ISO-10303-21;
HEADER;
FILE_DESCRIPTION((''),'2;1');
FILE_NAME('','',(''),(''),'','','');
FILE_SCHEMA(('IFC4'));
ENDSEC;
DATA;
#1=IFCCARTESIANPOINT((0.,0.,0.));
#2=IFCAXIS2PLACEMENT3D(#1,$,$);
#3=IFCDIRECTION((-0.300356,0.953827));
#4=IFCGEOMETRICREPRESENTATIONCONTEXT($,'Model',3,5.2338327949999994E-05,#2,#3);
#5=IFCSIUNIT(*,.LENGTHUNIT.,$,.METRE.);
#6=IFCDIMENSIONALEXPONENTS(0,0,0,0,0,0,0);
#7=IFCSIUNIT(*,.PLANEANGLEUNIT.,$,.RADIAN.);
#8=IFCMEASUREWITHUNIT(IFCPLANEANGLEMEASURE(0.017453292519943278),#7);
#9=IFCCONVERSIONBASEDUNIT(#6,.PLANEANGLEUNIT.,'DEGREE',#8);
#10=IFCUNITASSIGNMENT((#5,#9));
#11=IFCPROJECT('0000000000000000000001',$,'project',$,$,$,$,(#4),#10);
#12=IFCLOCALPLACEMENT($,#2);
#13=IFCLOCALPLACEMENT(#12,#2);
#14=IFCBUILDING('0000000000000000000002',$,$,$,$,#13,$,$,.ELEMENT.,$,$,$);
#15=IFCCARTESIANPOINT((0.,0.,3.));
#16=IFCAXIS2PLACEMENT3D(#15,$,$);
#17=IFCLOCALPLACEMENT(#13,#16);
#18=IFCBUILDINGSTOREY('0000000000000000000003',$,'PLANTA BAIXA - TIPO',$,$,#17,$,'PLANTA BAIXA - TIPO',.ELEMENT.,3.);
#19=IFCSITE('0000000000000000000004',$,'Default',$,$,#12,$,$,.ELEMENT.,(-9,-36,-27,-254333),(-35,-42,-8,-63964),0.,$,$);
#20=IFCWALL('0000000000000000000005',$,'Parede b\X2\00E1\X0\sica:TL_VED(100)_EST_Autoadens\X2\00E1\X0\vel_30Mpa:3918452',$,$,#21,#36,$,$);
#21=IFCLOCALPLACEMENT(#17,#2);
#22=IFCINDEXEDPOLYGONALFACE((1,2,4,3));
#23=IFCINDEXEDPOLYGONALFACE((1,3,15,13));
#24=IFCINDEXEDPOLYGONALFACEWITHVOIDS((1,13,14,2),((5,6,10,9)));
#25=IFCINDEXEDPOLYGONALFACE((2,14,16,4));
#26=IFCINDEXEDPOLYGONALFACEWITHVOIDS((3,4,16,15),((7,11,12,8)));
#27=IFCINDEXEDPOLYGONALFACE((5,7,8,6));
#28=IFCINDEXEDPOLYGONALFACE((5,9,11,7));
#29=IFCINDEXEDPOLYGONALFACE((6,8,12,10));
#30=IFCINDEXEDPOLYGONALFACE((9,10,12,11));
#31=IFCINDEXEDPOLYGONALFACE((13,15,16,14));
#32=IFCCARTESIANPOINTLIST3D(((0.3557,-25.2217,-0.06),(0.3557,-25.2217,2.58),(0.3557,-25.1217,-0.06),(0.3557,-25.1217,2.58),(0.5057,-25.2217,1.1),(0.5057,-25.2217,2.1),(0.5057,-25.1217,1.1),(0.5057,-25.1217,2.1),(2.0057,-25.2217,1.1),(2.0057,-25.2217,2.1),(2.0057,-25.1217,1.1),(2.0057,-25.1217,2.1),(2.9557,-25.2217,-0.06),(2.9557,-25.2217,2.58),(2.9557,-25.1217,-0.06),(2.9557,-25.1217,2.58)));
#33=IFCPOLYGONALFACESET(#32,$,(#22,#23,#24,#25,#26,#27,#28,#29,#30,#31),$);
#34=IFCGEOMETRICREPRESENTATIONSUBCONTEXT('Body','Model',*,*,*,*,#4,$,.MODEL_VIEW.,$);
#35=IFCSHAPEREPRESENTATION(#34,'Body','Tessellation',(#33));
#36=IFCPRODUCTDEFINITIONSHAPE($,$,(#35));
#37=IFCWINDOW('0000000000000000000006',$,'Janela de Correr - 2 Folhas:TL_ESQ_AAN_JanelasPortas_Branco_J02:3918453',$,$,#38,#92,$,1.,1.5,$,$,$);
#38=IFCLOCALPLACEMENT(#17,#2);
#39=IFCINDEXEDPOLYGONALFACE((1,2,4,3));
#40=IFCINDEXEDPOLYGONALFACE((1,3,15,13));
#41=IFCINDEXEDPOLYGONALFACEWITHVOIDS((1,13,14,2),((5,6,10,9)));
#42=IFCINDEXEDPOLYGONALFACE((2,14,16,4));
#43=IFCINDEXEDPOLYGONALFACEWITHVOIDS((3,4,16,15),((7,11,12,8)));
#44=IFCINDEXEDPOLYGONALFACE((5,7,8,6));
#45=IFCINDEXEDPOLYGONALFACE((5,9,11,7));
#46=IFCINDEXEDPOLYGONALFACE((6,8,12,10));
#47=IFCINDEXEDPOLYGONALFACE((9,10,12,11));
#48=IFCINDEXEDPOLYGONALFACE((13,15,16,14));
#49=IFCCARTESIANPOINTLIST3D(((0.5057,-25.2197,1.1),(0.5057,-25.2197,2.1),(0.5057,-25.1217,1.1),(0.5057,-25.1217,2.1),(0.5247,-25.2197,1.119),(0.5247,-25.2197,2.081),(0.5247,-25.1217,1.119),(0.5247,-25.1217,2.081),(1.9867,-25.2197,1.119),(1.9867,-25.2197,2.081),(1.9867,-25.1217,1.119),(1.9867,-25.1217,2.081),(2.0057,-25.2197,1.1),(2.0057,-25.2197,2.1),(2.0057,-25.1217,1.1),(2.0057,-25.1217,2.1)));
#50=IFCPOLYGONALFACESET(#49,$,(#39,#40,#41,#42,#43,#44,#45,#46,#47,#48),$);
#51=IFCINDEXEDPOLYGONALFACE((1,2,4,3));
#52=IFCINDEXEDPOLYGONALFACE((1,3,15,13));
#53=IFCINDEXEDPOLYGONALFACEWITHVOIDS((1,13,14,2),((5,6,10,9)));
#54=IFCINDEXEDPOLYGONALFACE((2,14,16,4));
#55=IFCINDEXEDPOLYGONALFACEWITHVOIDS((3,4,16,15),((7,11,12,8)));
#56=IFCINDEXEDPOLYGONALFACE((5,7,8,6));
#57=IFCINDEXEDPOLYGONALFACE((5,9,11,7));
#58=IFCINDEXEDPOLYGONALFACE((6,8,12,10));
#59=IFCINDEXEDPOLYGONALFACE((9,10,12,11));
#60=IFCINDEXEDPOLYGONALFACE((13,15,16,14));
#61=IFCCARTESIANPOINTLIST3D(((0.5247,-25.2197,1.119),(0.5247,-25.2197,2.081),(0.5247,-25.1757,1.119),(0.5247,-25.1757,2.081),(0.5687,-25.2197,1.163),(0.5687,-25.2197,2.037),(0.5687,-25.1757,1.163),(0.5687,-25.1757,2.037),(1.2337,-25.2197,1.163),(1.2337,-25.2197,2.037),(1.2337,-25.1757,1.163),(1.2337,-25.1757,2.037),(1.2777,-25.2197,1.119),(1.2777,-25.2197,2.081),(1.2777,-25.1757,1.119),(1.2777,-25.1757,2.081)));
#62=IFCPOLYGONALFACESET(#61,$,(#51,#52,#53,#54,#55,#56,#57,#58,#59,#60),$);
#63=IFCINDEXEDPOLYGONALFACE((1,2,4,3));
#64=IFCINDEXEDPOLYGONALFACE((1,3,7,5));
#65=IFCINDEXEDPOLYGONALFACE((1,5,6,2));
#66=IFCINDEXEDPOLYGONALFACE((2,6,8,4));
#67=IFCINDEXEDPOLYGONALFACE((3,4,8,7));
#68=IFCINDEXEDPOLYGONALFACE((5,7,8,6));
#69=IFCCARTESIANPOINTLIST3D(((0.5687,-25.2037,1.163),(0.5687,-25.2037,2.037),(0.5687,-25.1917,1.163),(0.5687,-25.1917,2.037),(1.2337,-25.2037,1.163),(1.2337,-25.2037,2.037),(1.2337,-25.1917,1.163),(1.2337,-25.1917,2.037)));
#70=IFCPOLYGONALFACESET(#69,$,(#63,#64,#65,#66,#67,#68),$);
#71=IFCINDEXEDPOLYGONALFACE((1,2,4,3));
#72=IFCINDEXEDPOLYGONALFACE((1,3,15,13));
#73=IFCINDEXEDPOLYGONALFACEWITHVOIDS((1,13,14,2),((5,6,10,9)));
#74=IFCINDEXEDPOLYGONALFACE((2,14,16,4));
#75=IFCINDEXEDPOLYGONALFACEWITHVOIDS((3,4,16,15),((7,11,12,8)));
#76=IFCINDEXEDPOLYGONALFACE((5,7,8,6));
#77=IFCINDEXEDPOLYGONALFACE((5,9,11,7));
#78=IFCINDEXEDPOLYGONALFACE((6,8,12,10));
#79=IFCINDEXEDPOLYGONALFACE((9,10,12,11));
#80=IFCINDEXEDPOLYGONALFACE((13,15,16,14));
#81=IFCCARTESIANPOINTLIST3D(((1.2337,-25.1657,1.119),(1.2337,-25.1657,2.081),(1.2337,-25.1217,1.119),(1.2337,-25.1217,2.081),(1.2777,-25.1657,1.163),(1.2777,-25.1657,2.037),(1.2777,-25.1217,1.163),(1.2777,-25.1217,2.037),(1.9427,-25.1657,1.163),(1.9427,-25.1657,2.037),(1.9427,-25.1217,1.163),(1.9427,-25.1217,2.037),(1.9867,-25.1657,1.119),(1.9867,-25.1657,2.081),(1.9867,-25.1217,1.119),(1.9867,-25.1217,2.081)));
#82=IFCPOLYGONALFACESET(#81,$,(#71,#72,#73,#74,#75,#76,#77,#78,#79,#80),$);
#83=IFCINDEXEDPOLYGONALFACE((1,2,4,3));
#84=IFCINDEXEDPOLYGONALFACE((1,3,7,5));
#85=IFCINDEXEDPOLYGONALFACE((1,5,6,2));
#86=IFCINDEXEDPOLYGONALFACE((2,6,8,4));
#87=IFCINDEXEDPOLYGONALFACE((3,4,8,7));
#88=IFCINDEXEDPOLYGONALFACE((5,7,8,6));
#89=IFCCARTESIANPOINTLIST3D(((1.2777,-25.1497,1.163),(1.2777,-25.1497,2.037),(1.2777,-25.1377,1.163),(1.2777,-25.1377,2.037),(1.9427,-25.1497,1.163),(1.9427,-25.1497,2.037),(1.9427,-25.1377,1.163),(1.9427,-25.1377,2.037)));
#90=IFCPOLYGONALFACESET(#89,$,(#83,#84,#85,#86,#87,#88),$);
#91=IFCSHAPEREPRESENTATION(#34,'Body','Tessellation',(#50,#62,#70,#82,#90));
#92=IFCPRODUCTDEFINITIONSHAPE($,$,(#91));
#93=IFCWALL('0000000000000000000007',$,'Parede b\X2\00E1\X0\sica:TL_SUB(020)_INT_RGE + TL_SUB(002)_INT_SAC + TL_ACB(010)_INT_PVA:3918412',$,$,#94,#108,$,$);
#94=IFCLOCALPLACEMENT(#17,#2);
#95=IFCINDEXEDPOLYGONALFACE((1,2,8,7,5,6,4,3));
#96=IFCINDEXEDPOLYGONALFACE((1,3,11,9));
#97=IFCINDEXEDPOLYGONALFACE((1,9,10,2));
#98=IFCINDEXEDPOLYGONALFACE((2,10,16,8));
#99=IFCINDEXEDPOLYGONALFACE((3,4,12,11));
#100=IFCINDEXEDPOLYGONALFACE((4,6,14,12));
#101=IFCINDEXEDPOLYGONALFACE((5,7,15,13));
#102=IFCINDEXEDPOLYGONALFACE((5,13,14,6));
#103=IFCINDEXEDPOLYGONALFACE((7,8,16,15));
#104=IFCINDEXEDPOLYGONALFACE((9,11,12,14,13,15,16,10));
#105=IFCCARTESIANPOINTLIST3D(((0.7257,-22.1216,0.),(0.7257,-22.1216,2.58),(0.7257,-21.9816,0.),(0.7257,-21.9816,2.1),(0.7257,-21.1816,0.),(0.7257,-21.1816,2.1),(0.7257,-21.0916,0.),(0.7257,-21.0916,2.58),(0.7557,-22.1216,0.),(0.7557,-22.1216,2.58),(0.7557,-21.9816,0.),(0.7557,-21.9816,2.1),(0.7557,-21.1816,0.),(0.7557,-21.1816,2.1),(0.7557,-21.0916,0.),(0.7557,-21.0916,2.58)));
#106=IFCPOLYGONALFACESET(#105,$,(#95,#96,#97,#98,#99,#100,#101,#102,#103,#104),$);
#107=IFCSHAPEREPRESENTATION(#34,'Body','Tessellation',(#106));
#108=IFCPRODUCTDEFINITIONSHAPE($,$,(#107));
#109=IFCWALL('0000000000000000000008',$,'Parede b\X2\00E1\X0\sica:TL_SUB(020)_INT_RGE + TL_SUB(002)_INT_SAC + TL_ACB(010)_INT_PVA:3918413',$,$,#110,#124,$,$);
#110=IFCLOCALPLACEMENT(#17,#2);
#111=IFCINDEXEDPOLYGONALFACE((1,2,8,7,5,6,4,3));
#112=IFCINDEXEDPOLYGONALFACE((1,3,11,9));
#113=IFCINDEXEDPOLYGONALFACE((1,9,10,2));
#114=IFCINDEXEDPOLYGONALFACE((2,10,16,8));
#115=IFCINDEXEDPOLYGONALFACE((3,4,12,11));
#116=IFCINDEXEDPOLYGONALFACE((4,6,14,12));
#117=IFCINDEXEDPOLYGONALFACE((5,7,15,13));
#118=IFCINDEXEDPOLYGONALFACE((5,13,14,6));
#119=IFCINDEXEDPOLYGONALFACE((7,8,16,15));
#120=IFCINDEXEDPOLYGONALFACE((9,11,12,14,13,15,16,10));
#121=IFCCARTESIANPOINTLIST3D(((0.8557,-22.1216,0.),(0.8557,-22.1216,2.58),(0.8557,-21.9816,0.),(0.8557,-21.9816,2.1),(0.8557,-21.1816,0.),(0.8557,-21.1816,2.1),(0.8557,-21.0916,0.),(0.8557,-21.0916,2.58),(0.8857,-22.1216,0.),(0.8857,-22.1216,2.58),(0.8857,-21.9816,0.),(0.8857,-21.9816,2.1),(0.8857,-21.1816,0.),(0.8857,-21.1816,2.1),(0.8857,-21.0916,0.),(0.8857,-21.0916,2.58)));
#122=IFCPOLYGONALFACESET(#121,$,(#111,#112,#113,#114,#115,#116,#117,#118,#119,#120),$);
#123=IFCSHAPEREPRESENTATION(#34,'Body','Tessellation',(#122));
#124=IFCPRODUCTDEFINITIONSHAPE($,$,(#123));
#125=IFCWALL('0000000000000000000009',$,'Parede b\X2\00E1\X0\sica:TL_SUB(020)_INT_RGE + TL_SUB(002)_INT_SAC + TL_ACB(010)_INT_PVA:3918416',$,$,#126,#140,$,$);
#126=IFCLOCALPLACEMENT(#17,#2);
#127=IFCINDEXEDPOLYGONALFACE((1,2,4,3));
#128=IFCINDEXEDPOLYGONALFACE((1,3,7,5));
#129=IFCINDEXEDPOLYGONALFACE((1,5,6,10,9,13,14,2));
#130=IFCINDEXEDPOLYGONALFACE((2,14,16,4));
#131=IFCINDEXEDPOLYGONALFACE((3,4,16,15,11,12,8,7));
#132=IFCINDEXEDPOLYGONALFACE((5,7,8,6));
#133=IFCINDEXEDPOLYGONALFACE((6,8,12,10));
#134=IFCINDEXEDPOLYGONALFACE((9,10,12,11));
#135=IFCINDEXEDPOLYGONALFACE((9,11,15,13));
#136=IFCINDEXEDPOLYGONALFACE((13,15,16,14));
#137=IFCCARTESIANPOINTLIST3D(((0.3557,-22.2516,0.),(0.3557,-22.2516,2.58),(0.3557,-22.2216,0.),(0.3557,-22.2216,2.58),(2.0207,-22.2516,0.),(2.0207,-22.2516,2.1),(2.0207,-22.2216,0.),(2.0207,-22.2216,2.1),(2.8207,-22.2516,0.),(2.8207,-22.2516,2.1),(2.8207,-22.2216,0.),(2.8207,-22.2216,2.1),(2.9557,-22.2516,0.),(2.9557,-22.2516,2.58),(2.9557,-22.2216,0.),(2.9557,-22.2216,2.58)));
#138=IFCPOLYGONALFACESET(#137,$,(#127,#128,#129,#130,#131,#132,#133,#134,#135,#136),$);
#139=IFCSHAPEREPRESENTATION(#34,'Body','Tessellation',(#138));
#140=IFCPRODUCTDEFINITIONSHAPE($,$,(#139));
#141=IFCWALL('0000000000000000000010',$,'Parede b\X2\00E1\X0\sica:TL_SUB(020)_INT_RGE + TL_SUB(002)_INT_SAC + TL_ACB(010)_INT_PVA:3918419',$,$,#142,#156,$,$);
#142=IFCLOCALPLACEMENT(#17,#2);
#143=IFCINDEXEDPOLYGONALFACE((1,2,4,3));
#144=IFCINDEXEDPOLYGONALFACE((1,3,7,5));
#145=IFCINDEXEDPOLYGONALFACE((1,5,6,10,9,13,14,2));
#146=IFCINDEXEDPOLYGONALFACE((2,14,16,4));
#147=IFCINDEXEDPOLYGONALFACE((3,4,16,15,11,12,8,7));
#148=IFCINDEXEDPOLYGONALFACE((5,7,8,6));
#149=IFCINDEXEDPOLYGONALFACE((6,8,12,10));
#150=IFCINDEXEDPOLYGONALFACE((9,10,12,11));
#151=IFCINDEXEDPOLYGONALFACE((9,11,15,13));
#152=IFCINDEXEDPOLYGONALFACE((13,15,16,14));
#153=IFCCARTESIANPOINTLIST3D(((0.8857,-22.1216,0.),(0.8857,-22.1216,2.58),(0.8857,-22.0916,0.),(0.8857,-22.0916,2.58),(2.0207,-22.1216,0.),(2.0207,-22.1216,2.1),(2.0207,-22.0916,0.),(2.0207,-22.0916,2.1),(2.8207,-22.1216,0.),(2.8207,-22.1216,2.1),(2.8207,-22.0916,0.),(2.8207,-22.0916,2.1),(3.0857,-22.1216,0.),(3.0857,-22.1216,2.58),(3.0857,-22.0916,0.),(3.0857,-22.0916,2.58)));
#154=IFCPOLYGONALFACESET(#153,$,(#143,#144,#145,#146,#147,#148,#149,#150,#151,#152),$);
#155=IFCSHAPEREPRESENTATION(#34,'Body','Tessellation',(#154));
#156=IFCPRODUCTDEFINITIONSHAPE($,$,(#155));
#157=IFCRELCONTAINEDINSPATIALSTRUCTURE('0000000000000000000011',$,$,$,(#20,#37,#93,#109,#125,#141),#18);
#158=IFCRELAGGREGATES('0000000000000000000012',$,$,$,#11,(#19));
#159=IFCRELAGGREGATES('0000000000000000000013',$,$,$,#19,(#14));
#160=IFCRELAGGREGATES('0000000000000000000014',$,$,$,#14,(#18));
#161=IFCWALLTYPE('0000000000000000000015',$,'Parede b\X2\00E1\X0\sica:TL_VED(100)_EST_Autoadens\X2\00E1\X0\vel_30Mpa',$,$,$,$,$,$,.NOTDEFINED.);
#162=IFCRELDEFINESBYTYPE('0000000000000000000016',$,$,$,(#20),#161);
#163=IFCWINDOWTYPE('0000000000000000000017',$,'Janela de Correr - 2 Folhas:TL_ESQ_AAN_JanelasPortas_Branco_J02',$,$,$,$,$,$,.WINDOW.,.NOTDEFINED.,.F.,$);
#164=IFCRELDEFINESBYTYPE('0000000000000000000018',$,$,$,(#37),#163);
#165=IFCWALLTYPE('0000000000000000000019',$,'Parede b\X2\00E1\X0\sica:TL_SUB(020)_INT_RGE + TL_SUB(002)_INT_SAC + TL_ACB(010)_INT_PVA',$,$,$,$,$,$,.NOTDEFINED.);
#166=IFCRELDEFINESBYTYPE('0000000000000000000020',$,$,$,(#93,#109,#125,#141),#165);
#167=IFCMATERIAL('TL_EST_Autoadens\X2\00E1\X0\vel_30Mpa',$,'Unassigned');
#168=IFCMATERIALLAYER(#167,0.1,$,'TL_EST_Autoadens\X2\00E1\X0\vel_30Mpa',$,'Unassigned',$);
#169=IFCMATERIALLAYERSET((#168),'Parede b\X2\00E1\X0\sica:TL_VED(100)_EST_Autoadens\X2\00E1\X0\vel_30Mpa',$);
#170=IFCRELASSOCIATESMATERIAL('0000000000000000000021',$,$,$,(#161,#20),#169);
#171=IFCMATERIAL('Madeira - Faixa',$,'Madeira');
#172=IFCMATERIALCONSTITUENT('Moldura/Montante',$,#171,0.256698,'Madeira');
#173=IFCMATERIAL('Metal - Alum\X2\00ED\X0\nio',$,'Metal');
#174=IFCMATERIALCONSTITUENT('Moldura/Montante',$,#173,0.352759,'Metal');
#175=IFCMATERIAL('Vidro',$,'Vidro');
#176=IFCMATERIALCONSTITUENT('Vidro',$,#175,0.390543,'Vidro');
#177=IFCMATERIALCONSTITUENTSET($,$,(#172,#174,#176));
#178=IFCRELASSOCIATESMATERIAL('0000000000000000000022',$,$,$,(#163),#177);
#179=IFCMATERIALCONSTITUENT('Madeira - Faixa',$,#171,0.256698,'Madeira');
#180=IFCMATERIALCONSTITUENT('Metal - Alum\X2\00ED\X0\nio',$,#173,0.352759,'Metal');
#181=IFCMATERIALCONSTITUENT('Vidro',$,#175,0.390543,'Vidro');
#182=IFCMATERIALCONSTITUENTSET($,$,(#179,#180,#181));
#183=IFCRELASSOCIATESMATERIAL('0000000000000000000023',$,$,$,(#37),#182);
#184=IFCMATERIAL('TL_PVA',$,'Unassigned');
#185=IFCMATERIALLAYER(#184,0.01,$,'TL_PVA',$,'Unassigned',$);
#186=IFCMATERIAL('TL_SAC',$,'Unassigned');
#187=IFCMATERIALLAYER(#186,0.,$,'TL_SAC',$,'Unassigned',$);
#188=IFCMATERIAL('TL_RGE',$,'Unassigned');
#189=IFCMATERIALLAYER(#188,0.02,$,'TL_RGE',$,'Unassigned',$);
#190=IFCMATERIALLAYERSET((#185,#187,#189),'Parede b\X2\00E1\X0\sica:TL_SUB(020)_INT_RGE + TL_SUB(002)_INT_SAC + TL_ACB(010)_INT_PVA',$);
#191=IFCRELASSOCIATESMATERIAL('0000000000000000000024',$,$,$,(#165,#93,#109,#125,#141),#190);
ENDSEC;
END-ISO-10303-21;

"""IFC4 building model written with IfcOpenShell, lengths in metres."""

from ifc_helpers import new_model, entity, si_unit, converted_unit, direction, frame, frame_2d, origin, origin_2d_with_axis, place, context, subcontext, project, spatial, polyline, rectangle, outline, extrude, source, transform, mapped, material, layer, layer_set, layer_usage, constituent, constituent_set, type_object, type_shapes, element, fill, save


model = new_model("IFC4")

# Units and contexts
model_context = context("Model", 3, precision=5.2338327949999994e-05, world=origin(), true_north=direction((-0.300356, 0.953827)))
body_context = subcontext(model_context, "Body", "Model", "MODEL_VIEW")
ifc_project = project(units=[si_unit("LENGTHUNIT", "METRE"), converted_unit("PLANEANGLEUNIT", "DEGREE", entity("IfcPlaneAngleMeasure", 0.017453292519943278), si_unit("PLANEANGLEUNIT", "RADIAN"), dimensions=[0, 0, 0, 0, 0, 0, 0])], contexts=[model_context])

# Site, building, storey
site_placement = place(None, origin())
site = spatial("IfcSite", under=ifc_project, at=site_placement, Name="Default", CompositionType="ELEMENT", RefLatitude=(-9, -36, -27, -254333), RefLongitude=(-35, -42, -8, -63964), RefElevation=0.0)
building_placement = place(site_placement, origin())
building = spatial("IfcBuilding", under=site, at=building_placement, CompositionType="ELEMENT")
storey_placement = place(building_placement, frame((0.0, 0.0, 3.0)))
storey = spatial("IfcBuildingStorey", under=building, at=storey_placement, Name="PLANTA BAIXA - TIPO", LongName="PLANTA BAIXA - TIPO", CompositionType="ELEMENT", Elevation=3.0)

# Shared definitions
ifc_material_1 = material(Name="TL_EST_Autoadensável_30Mpa", Category="Unassigned")
ifc_layer_1 = layer(ifc_material_1, 0.1, Name="TL_EST_Autoadensável_30Mpa", Category="Unassigned")
ifc_layer_set_1 = layer_set([ifc_layer_1], Name="Parede básica:TL_VED(100)_EST_Autoadensável_30Mpa")
wall_type_1 = type_object("IfcWallType", Name="Parede básica:TL_VED(100)_EST_Autoadensável_30Mpa", PredefinedType="NOTDEFINED", material=ifc_layer_set_1)

# Shared definitions
ifc_material_2 = material(Name="Vidro", Category="Vidro")

# Wall, opening, window
ifc_layer_usage_1 = layer_usage(ifc_layer_set_1, "AXIS2", "POSITIVE", -0.05)
wall_1_placement = place(storey_placement, frame((0.3557, -25.1717, -0.06)))
wall_1 = element("IfcWall", 1, at=wall_1_placement, inside=storey, type_object=wall_type_1, material=ifc_layer_usage_1, Name="Parede básica:TL_VED(100)_EST_Autoadensável_30Mpa:3918452", context=body_context, shape_type="SweptSolid", body=[
    extrude(rectangle(XDim=2.6, YDim=0.1, at=frame_2d((1.3, 0.0), x_axis=(-1.0, 0.0))), origin(), (0.0, 0.0, 1.0), 2.64),
])
opening_1_placement = place(wall_1_placement, frame((1.65, 0.05, 1.16)))
opening_1 = element("IfcOpeningElement", 2, at=opening_1_placement, cuts=wall_1, PredefinedType="OPENING", context=body_context, shape_type="SweptSolid", body=[
    extrude(rectangle(XDim=1.0, YDim=1.5, at=frame_2d((0.5, 0.75), x_axis=(-1.0, 0.0))), frame((0.0, 0.0, 0.0), z_axis=(0.0, -1.0, 0.0), x_axis=(0.0, 0.0, 1.0)), (0.0, 0.0, 1.0), 0.1),
])
ifc_material_3 = material(Name="Madeira - Faixa", Category="Madeira")
ifc_constituent_1 = constituent(ifc_material_3, Name="Madeira - Faixa", Category="Madeira", fraction=0.256698)
ifc_material_4 = material(Name="Metal - Alumínio", Category="Metal")
ifc_constituent_2 = constituent(ifc_material_4, Name="Metal - Alumínio", Category="Metal", fraction=0.352759)
ifc_constituent_3 = constituent(ifc_material_2, Name="Vidro", Category="Vidro", fraction=0.390543)
ifc_constituent_set_1 = constituent_set(constituents=[ifc_constituent_1, ifc_constituent_2, ifc_constituent_3])
ifc_constituent_4 = constituent(ifc_material_3, Name="Moldura/Montante", Category="Madeira", fraction=0.256698)
ifc_constituent_5 = constituent(ifc_material_4, Name="Moldura/Montante", Category="Metal", fraction=0.352759)
ifc_constituent_6 = constituent(ifc_material_2, Name="Vidro", Category="Vidro", fraction=0.390543)
ifc_constituent_set_2 = constituent_set(constituents=[ifc_constituent_4, ifc_constituent_5, ifc_constituent_6])
window_type = type_object("IfcWindowType", Name="Janela de Correr - 2 Folhas:TL_ESQ_AAN_JanelasPortas_Branco_J02", ParameterTakesPrecedence=False, PartitioningType="NOTDEFINED", PredefinedType="WINDOW", material=ifc_constituent_set_2)
shared_shape_1 = source(origin(), body_context, "Body", "SweptSolid", [
    extrude(outline(polyline([(-0.75, -0.5), (0.75, -0.5), (0.75, 0.5), (-0.75, 0.5), (-0.75, -0.5)]), holes=[polyline([(-0.731, -0.481), (-0.731, 0.481), (0.731, 0.481), (0.731, -0.481), (-0.731, -0.481)])]), frame((0.75, 0.0, 0.5), z_axis=(0.0, 1.0, 0.0), x_axis=(1.0, 0.0, 0.0)), (0.0, 0.0, 1.0), 0.098),
    extrude(outline(polyline([(-0.3765, -0.481), (0.3765, -0.481), (0.3765, 0.481), (-0.3765, 0.481), (-0.3765, -0.481)]), holes=[polyline([(-0.3325, -0.437), (-0.3325, 0.437), (0.3325, 0.437), (0.3325, -0.437), (-0.3325, -0.437)])]), frame((1.1045, 0.054, 0.5), z_axis=(0.0, 1.0, 0.0), x_axis=(1.0, 0.0, 0.0)), (0.0, 0.0, 1.0), 0.044),
    extrude(rectangle(XDim=0.012, YDim=0.665, at=origin_2d_with_axis()), frame((1.1045, 0.076, 0.063), z_axis=(0.0, 0.0, 1.0), x_axis=(0.0, -1.0, 0.0)), (0.0, 0.0, 1.0), 0.874),
    extrude(outline(polyline([(-0.481, -0.3765), (0.481, -0.3765), (0.481, 0.3765), (-0.481, 0.3765), (-0.481, -0.3765)]), holes=[polyline([(-0.437, -0.3325), (-0.437, 0.3325), (0.437, 0.3325), (0.437, -0.3325), (-0.437, -0.3325)])]), frame((0.3955, 0.0, 0.5), z_axis=(0.0, 1.0, 0.0), x_axis=(0.0, 0.0, -1.0)), (0.0, 0.0, 1.0), 0.044),
    extrude(rectangle(XDim=0.012, YDim=0.665, at=origin_2d_with_axis()), frame((0.3955, 0.022, 0.063), z_axis=(0.0, 0.0, 1.0), x_axis=(0.0, -1.0, 0.0)), (0.0, 0.0, 1.0), 0.874),
])
type_shapes(window_type, [shared_shape_1])
window_placement = place(opening_1_placement, frame((0.0, 0.0, 0.0), z_axis=(0.0, 0.0, 1.0), x_axis=(-1.0, 0.0, 0.0)))
window = element("IfcWindow", 3, at=window_placement, inside=storey, type_object=window_type, material=ifc_constituent_set_1, Name="Janela de Correr - 2 Folhas:TL_ESQ_AAN_JanelasPortas_Branco_J02:3918453", OverallHeight=1.0, OverallWidth=1.5, context=body_context, shape_type="MappedRepresentation", body=[
    mapped(shared_shape_1, transform((0.0, 0.0, 0.0), scale=1.0)),
])
fill(opening_1, window)

# Walls, openings
ifc_material_5 = material(Name="TL_PVA", Category="Unassigned")
ifc_layer_2 = layer(ifc_material_5, 0.01, Name="TL_PVA", Category="Unassigned")
ifc_material_6 = material(Name="TL_SAC", Category="Unassigned")
ifc_layer_3 = layer(ifc_material_6, 0.0, Name="TL_SAC", Category="Unassigned")
ifc_material_7 = material(Name="TL_RGE", Category="Unassigned")
ifc_layer_4 = layer(ifc_material_7, 0.02, Name="TL_RGE", Category="Unassigned")
ifc_layer_set_2 = layer_set([ifc_layer_2, ifc_layer_3, ifc_layer_4], Name="Parede básica:TL_SUB(020)_INT_RGE + TL_SUB(002)_INT_SAC + TL_ACB(010)_INT_PVA")
ifc_layer_usage_2 = layer_usage(ifc_layer_set_2, "AXIS2", "NEGATIVE", 0.015)
wall_type_2 = type_object("IfcWallType", Name="Parede básica:TL_SUB(020)_INT_RGE + TL_SUB(002)_INT_SAC + TL_ACB(010)_INT_PVA", PredefinedType="NOTDEFINED", material=ifc_layer_set_2)
wall_2_placement = place(storey_placement, frame((0.7407, -22.1216, 0.0), z_axis=(0.0, 0.0, 1.0), x_axis=(0.0, 1.0, 0.0)))
wall_2 = element("IfcWall", 4, at=wall_2_placement, inside=storey, type_object=wall_type_2, material=ifc_layer_usage_2, Name="Parede básica:TL_SUB(020)_INT_RGE + TL_SUB(002)_INT_SAC + TL_ACB(010)_INT_PVA:3918412", context=body_context, shape_type="SweptSolid", body=[
    extrude(rectangle(XDim=1.03, YDim=0.03, at=frame_2d((0.515, 0.0), x_axis=(1.0, 0.0))), origin(), (0.0, 0.0, 1.0), 2.58),
])
opening_2_placement = place(wall_2_placement, frame((22.1216, 0.7407, 0.0)))
element("IfcOpeningElement", 5, at=opening_2_placement, cuts=wall_2, PredefinedType="OPENING", context=body_context, shape_type="SweptSolid", body=[
    extrude(rectangle(XDim=2.1, YDim=0.8, at=frame_2d((0.0, 0.0), x_axis=(0.0, 1.0))), frame((-21.5816, -2.3797, 1.05), z_axis=(0.0, 1.0, 0.0), x_axis=(-1.0, 0.0, 0.0)), (0.0, 0.0, 1.0), 3.048),
])
ifc_layer_usage_3 = layer_usage(ifc_layer_set_2, "AXIS2", "NEGATIVE", 0.015)
wall_3_placement = place(storey_placement, frame((0.8707, -21.0916, 0.0), z_axis=(0.0, 0.0, 1.0), x_axis=(0.0, -1.0, 0.0)))
wall_3 = element("IfcWall", 6, at=wall_3_placement, inside=storey, type_object=wall_type_2, material=ifc_layer_usage_3, Name="Parede básica:TL_SUB(020)_INT_RGE + TL_SUB(002)_INT_SAC + TL_ACB(010)_INT_PVA:3918413", context=body_context, shape_type="SweptSolid", body=[
    extrude(rectangle(XDim=1.03, YDim=0.03, at=frame_2d((0.515, 0.0), x_axis=(1.0, 0.0))), origin(), (0.0, 0.0, 1.0), 2.58),
])
opening_3_placement = place(wall_3_placement, frame((-21.0916, -0.8707, 0.0)))
element("IfcOpeningElement", 7, at=opening_3_placement, cuts=wall_3, PredefinedType="OPENING", context=body_context, shape_type="SweptSolid", body=[
    extrude(rectangle(XDim=2.1, YDim=0.8, at=frame_2d((0.0, 0.0), x_axis=(1.0, 0.0))), frame((21.5816, -0.6683, 1.05), z_axis=(0.0, 1.0, 0.0), x_axis=(0.0, 0.0, 1.0)), (0.0, 0.0, 1.0), 3.048),
])
ifc_layer_usage_4 = layer_usage(ifc_layer_set_2, "AXIS2", "NEGATIVE", 0.015)
wall_4_placement = place(storey_placement, frame((2.9557, -22.2366, 0.0), z_axis=(0.0, 0.0, 1.0), x_axis=(-1.0, 0.0, 0.0)))
wall_4 = element("IfcWall", 8, at=wall_4_placement, inside=storey, type_object=wall_type_2, material=ifc_layer_usage_4, Name="Parede básica:TL_SUB(020)_INT_RGE + TL_SUB(002)_INT_SAC + TL_ACB(010)_INT_PVA:3918416", context=body_context, shape_type="SweptSolid", body=[
    extrude(rectangle(XDim=2.6, YDim=0.03, at=frame_2d((1.3, 0.0), x_axis=(-1.0, 0.0))), origin(), (0.0, 0.0, 1.0), 2.58),
])
opening_4_placement = place(wall_4_placement, frame((2.9557, -22.2366, 0.0)))
element("IfcOpeningElement", 9, at=opening_4_placement, cuts=wall_4, PredefinedType="OPENING", context=body_context, shape_type="SweptSolid", body=[
    extrude(rectangle(XDim=2.1, YDim=0.8, at=frame_2d((0.0, 0.0), x_axis=(1.0, 0.0))), frame((-2.4207, 20.5976, 1.05), z_axis=(0.0, 1.0, 0.0), x_axis=(0.0, 0.0, 1.0)), (0.0, 0.0, 1.0), 3.048),
])
ifc_layer_usage_5 = layer_usage(ifc_layer_set_2, "AXIS2", "NEGATIVE", 0.015)
wall_5_placement = place(storey_placement, frame((0.8857, -22.1066, 0.0)))
wall_5 = element("IfcWall", 10, at=wall_5_placement, inside=storey, type_object=wall_type_2, material=ifc_layer_usage_5, Name="Parede básica:TL_SUB(020)_INT_RGE + TL_SUB(002)_INT_SAC + TL_ACB(010)_INT_PVA:3918419", context=body_context, shape_type="SweptSolid", body=[
    extrude(rectangle(XDim=2.2, YDim=0.03, at=frame_2d((1.1, 0.0), x_axis=(1.0, 0.0))), origin(), (0.0, 0.0, 1.0), 2.58),
])
opening_5_placement = place(wall_5_placement, frame((-0.8857, 22.1066, 0.0)))
element("IfcOpeningElement", 11, at=opening_5_placement, cuts=wall_5, PredefinedType="OPENING", context=body_context, shape_type="SweptSolid", body=[
    extrude(rectangle(XDim=2.1, YDim=0.8, at=frame_2d((0.0, 0.0), x_axis=(0.0, 1.0))), frame((2.4207, -23.6456, 1.05), z_axis=(0.0, 1.0, 0.0), x_axis=(-1.0, 0.0, 0.0)), (0.0, 0.0, 1.0), 3.048),
])

save(model, "model.ifc")
